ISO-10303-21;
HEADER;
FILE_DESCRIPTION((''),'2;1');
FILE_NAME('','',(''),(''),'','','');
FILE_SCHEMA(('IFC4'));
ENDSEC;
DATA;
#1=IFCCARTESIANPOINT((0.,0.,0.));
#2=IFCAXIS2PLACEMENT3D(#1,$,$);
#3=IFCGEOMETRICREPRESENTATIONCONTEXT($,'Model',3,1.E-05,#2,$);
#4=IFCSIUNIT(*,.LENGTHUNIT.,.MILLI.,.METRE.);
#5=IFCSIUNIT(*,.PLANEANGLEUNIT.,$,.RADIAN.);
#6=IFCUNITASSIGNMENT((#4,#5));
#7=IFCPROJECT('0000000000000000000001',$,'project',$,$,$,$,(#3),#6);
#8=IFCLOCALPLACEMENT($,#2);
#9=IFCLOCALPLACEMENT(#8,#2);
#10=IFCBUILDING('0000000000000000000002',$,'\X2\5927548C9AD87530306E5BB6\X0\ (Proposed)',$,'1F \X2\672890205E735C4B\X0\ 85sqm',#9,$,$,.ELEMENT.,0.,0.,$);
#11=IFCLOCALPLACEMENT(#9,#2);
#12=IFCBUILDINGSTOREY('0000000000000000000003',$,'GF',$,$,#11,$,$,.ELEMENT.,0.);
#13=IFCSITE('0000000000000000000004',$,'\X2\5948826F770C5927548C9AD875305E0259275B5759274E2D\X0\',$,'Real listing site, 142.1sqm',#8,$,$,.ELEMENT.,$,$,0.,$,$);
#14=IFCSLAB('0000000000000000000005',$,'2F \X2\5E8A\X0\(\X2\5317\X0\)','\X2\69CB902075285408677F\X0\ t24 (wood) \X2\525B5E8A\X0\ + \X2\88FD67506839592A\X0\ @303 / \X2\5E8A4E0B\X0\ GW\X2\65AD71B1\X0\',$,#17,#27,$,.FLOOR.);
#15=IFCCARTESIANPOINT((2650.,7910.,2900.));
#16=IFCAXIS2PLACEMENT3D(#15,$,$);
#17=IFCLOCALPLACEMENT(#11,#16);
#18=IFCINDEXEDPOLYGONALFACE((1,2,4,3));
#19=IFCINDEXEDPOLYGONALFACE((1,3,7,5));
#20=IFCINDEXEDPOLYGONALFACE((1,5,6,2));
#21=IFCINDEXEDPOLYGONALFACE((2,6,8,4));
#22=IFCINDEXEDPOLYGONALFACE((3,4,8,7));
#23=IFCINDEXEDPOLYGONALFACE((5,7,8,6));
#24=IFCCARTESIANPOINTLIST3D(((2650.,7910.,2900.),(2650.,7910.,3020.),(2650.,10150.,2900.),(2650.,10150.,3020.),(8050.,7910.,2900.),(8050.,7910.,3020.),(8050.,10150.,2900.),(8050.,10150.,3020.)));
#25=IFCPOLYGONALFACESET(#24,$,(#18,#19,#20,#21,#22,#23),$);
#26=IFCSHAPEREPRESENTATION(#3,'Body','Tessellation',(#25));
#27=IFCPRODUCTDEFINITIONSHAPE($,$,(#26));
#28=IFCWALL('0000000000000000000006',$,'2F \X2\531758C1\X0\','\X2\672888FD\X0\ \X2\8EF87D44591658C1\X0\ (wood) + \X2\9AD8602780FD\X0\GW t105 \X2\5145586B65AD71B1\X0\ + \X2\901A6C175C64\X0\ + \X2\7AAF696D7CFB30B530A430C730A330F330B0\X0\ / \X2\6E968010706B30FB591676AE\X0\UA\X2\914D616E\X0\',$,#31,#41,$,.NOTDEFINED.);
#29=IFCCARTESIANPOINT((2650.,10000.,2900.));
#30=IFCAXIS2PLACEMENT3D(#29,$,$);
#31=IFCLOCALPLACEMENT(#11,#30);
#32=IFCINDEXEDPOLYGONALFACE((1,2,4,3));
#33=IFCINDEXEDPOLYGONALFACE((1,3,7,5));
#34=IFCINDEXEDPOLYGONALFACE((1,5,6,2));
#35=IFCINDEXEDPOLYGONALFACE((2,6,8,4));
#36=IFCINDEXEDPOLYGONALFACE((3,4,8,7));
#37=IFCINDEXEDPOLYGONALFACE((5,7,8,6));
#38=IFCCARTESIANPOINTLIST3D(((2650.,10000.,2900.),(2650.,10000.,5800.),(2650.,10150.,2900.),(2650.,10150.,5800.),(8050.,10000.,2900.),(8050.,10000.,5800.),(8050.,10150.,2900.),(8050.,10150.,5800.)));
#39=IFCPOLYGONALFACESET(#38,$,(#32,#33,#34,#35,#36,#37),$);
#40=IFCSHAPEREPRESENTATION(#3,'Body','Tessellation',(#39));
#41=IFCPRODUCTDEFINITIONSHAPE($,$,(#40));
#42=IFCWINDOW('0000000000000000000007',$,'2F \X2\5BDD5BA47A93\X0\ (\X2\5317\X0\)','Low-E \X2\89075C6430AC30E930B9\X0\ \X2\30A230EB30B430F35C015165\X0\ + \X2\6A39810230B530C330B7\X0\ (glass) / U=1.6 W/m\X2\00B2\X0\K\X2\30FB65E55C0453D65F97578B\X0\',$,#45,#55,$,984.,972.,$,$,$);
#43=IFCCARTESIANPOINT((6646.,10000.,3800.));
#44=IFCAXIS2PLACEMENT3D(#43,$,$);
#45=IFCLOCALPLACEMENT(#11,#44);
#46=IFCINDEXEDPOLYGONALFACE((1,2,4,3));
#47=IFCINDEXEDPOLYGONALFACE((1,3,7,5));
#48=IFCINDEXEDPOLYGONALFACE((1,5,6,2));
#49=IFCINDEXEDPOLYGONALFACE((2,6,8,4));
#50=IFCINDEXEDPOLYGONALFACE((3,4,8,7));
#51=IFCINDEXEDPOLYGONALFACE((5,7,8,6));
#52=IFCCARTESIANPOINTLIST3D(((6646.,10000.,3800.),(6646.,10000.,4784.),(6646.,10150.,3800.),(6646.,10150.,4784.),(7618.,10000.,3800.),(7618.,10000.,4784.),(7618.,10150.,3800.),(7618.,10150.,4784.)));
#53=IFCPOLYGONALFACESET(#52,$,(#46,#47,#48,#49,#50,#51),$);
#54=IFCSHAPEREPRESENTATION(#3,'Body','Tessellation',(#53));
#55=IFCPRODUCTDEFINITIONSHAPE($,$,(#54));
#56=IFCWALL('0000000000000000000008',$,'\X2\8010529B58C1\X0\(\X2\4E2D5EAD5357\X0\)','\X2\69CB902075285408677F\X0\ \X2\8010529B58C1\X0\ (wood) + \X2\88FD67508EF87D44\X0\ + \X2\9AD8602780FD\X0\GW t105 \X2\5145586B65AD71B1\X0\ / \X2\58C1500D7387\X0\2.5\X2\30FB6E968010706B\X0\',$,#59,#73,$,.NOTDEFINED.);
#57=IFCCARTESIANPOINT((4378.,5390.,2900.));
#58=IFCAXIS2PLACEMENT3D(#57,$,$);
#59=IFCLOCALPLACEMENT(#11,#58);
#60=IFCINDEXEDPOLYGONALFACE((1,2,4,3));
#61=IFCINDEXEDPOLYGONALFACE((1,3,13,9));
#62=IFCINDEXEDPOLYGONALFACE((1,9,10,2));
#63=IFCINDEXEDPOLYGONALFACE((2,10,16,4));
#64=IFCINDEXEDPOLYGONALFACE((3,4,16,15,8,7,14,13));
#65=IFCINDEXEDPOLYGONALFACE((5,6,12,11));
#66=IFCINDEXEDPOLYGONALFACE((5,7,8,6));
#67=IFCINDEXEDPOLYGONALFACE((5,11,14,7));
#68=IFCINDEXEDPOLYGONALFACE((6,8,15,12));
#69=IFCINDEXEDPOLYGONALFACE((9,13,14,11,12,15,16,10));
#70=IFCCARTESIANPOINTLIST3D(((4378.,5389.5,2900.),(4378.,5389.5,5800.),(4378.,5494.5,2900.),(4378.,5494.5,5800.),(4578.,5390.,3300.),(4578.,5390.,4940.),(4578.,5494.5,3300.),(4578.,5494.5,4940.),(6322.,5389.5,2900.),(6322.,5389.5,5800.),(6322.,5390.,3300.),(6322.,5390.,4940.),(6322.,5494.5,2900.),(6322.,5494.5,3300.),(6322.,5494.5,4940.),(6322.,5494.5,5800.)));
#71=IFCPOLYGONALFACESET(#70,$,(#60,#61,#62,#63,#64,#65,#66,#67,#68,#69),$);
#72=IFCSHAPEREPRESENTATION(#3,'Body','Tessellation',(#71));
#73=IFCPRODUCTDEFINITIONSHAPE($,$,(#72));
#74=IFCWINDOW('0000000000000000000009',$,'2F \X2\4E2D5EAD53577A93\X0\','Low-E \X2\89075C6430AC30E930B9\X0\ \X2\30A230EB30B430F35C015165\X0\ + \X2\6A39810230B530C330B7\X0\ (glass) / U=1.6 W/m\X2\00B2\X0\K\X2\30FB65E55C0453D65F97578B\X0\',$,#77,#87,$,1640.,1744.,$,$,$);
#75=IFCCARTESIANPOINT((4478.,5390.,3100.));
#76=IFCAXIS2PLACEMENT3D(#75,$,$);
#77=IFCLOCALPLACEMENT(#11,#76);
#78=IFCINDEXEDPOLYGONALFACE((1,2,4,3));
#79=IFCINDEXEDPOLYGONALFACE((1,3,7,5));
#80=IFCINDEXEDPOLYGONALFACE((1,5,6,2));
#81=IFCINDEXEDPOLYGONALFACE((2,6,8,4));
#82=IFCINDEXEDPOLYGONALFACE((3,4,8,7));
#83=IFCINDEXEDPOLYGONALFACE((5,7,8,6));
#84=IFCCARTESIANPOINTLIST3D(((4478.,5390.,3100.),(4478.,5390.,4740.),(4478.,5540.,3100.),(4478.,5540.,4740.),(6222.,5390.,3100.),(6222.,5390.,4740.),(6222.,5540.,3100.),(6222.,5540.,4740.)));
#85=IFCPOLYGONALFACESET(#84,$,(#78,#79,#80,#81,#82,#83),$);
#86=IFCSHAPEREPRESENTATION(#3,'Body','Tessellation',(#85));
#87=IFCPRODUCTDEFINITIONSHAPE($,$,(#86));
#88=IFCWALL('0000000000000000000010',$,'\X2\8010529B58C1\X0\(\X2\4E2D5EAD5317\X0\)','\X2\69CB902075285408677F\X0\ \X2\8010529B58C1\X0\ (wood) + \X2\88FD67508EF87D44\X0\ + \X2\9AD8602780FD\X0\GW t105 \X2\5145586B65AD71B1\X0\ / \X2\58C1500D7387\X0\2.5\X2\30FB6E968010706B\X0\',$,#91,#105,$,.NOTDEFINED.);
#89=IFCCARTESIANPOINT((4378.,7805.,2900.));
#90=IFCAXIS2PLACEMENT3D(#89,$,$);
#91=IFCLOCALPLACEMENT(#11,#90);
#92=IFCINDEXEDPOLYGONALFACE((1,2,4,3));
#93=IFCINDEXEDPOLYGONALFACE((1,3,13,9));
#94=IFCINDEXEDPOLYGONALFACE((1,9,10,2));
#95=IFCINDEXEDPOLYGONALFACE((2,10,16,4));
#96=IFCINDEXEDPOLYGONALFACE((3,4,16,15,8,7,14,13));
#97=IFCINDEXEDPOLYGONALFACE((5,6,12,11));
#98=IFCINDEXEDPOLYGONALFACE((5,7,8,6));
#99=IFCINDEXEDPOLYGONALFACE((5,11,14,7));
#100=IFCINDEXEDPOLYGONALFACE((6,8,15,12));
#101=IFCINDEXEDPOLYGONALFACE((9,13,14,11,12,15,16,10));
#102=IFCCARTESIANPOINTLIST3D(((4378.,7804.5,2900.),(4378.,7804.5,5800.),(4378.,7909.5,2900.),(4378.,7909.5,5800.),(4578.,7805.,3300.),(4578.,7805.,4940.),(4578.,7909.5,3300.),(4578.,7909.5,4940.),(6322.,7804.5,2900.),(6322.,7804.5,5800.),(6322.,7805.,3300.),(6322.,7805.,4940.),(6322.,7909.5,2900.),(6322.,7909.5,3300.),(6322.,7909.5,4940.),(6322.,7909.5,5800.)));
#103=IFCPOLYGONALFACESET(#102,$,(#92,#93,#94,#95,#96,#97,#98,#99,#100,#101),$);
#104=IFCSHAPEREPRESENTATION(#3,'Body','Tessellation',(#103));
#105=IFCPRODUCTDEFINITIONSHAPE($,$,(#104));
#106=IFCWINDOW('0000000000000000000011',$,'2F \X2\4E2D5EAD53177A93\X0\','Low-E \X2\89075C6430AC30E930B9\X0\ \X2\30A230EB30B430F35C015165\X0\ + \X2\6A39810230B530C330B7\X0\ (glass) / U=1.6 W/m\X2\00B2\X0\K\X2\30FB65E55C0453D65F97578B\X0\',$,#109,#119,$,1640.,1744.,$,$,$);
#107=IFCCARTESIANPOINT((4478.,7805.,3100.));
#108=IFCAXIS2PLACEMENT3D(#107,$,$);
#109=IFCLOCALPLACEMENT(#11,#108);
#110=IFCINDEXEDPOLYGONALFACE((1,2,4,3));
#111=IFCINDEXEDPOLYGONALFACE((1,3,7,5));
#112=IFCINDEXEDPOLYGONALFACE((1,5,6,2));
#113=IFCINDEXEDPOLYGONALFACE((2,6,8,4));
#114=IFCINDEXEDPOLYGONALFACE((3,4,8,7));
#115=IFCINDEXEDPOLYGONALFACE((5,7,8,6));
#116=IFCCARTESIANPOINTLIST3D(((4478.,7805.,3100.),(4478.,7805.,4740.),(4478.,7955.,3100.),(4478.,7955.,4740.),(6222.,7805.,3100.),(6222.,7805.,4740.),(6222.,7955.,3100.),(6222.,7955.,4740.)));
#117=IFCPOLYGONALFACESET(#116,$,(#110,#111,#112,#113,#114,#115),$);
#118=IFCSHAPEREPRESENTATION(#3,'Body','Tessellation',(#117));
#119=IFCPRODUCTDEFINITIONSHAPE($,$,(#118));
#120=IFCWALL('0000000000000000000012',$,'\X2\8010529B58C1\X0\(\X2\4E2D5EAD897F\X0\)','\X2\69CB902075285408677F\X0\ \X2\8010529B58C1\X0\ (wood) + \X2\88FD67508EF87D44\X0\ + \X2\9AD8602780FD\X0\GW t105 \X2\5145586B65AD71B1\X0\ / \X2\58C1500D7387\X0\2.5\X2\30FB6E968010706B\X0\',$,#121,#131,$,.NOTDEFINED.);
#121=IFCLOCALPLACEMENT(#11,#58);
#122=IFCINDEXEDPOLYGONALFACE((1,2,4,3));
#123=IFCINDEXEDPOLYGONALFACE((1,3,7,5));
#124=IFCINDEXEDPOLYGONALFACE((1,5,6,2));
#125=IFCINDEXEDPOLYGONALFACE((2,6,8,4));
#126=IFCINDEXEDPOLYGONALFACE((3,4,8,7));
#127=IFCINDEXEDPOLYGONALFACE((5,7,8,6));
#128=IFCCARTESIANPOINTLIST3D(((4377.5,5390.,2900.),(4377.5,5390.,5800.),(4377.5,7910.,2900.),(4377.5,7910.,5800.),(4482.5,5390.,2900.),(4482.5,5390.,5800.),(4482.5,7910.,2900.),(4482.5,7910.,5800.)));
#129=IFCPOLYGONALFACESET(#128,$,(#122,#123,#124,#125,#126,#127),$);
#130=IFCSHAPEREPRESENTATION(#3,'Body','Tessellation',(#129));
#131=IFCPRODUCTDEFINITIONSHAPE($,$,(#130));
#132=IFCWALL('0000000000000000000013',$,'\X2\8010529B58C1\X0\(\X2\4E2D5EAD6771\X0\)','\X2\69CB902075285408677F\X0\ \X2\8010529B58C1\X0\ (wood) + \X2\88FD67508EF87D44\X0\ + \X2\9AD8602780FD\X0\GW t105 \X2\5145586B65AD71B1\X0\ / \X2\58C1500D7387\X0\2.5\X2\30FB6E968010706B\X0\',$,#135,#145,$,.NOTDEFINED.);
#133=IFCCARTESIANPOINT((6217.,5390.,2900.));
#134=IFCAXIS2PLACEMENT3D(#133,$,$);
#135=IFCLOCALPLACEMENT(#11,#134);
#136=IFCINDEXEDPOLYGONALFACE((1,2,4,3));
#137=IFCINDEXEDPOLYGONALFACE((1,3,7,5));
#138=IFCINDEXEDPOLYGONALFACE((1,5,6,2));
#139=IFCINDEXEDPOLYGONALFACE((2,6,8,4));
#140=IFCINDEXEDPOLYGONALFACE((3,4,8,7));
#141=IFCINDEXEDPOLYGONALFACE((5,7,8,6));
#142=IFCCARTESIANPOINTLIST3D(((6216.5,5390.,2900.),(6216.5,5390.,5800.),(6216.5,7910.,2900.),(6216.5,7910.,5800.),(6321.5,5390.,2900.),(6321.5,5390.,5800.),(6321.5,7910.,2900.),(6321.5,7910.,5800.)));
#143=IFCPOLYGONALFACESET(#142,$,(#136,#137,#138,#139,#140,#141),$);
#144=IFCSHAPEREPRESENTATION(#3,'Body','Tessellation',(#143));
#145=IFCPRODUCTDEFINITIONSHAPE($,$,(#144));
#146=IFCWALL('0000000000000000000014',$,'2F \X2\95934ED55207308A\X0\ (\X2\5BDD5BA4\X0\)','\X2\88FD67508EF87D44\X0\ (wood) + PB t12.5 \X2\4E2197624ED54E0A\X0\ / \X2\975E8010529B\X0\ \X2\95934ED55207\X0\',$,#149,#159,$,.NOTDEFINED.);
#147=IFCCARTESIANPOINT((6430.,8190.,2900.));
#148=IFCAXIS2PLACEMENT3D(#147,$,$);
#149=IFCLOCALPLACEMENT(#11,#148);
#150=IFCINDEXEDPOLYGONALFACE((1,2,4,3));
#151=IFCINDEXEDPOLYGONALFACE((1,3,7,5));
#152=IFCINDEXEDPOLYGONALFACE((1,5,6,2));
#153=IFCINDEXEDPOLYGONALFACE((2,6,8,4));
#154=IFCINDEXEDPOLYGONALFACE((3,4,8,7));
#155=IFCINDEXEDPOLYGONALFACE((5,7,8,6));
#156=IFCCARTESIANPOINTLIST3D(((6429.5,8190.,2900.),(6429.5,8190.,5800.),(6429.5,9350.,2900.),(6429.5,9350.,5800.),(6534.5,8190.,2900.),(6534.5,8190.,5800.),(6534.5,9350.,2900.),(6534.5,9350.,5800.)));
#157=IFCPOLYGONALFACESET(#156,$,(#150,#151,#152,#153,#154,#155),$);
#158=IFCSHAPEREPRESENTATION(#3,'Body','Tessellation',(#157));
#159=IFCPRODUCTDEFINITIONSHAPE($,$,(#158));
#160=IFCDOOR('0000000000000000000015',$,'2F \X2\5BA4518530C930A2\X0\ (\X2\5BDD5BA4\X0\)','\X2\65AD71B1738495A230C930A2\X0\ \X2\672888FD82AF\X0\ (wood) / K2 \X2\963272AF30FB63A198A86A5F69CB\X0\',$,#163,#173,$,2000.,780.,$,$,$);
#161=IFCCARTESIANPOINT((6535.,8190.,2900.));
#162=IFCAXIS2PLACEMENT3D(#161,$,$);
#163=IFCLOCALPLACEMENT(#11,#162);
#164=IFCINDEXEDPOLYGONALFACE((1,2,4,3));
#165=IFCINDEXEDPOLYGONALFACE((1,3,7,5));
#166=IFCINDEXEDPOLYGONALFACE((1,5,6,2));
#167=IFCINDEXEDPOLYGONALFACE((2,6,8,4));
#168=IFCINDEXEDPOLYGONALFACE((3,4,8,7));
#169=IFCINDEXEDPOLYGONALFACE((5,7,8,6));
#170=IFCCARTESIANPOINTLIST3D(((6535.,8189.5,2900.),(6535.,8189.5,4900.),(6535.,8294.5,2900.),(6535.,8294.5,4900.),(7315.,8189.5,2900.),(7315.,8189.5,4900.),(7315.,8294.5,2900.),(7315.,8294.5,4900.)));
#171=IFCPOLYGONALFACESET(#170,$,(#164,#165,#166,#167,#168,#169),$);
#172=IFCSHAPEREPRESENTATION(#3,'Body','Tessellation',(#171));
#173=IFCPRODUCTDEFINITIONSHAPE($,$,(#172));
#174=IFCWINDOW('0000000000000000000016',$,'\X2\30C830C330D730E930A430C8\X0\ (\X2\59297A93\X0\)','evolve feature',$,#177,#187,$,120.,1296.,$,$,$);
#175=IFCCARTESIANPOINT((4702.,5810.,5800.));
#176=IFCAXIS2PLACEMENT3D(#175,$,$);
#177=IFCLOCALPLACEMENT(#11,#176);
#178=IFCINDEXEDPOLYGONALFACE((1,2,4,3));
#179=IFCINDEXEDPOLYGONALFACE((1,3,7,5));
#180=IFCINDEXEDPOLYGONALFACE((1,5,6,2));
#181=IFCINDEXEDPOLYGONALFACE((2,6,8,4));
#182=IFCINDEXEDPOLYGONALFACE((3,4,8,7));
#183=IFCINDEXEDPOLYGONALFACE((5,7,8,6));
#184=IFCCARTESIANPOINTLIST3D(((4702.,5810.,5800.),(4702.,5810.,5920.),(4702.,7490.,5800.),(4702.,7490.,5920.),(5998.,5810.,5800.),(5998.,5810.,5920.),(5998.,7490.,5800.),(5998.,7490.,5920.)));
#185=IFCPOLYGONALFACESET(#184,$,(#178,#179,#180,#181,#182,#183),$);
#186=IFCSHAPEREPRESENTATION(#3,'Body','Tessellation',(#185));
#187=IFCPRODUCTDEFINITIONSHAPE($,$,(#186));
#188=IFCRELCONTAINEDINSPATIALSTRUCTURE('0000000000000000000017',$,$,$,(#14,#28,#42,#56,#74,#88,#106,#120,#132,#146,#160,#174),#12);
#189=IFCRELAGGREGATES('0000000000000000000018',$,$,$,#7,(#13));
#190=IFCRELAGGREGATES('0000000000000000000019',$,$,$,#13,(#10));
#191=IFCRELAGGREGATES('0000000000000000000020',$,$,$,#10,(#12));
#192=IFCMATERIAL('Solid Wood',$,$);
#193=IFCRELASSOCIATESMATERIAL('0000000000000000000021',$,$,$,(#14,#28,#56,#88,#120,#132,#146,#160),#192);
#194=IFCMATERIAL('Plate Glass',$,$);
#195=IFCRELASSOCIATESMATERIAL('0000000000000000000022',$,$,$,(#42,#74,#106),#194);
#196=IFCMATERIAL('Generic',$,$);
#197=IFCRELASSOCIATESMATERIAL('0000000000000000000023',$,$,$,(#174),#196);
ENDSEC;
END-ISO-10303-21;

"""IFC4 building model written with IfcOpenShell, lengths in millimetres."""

from ifc_helpers import new_model, si_unit, frame, frame_2d, origin, place, context, project, spatial, rectangle, extrude, material, element, fill, save


model = new_model("IFC4")

# Units and contexts
model_context = context("Model", 3, precision=1e-05, world=origin())
ifc_project = project(units=[si_unit("LENGTHUNIT", "METRE", prefix="MILLI"), si_unit("PLANEANGLEUNIT", "RADIAN")], contexts=[model_context])

# Site, building, storey
site_placement = place(None, origin())
site = spatial("IfcSite", under=ifc_project, at=site_placement, Name="奈良県大和高田市大字大中", ObjectType="Real listing site, 142.1sqm", CompositionType="ELEMENT", RefElevation=0.0)
building_placement = place(site_placement, origin())
building = spatial("IfcBuilding", under=site, at=building_placement, Name="大和高田の家 (Proposed)", ObjectType="1F 木造平屋 85sqm", CompositionType="ELEMENT", ElevationOfRefHeight=0.0, ElevationOfTerrain=0.0)
storey_placement = place(building_placement, origin())
storey = spatial("IfcBuildingStorey", under=building, at=storey_placement, Name="GF", CompositionType="ELEMENT", Elevation=0.0)

# Slab
ifc_material_1 = material(Name="Solid Wood")
slab_placement = place(storey_placement, frame((2650.0, 7910.0, 2900.0)))
element("IfcSlab", 1, at=slab_placement, inside=storey, material=ifc_material_1, Name="2F 床(北)", Description="構造用合板 t24 (wood) 剛床 + 製材根太 @303 / 床下 GW断熱", PredefinedType="FLOOR", context=model_context, shape_type="SweptSolid", body=[
    extrude(rectangle(XDim=5400.0, YDim=2240.0, at=frame_2d((2700.0, 1120.0))), frame((2650.0, 7910.0, 2900.0)), (0.0, 0.0, 1.0), 120.0),
])

# Walls, openings, windows
wall_1_placement = place(storey_placement, frame((2650.0, 10000.0, 2900.0)))
wall_1 = element("IfcWall", 2, at=wall_1_placement, inside=storey, material=ifc_material_1, Name="2F 北壁", Description="木製 軸組外壁 (wood) + 高性能GW t105 充填断熱 + 通気層 + 窯業系サイディング / 準耐火・外皮UA配慮", PredefinedType="NOTDEFINED", context=model_context, shape_type="SweptSolid", body=[
    extrude(rectangle(XDim=5400.0, YDim=150.0, at=frame_2d((2700.0, 75.0))), frame((2650.0, 10000.0, 2900.0)), (0.0, 0.0, 1.0), 2900.0),
])
opening_1_placement = place(storey_placement, frame((6646.0, 10000.0, 3800.0)))
opening_1 = element("IfcOpeningElement", 3, at=opening_1_placement, cuts=wall_1, PredefinedType="NOTDEFINED", context=model_context, shape_type="SweptSolid", body=[
    extrude(rectangle(XDim=972.0, YDim=150.0, at=frame_2d((486.0, 75.0))), frame((6646.0, 10000.0, 3800.0)), (0.0, 0.0, 1.0), 984.0),
])
ifc_material_2 = material(Name="Plate Glass")
window_1_placement = place(storey_placement, frame((6646.0, 10000.0, 3800.0)))
window_1 = element("IfcWindow", 4, at=window_1_placement, inside=storey, material=ifc_material_2, Name="2F 寝室窓 (北)", Description="Low-E 複層ガラス アルゴン封入 + 樹脂サッシ (glass) / U=1.6 W/m²K・日射取得型", OverallHeight=984.0, OverallWidth=972.0, context=model_context, shape_type="SweptSolid", body=[
    extrude(rectangle(XDim=972.0, YDim=150.0, at=frame_2d((486.0, 75.0))), frame((6646.0, 10000.0, 3800.0)), (0.0, 0.0, 1.0), 984.0),
])
fill(opening_1, window_1)
wall_2_placement = place(storey_placement, frame((4378.0, 5390.0, 2900.0)))
wall_2 = element("IfcWall", 5, at=wall_2_placement, inside=storey, material=ifc_material_1, Name="耐力壁(中庭南)", Description="構造用合板 耐力壁 (wood) + 製材軸組 + 高性能GW t105 充填断熱 / 壁倍率2.5・準耐火", PredefinedType="NOTDEFINED", context=model_context, shape_type="SweptSolid", body=[
    extrude(rectangle(XDim=1944.0, YDim=105.0, at=frame_2d((972.0, 52.0))), frame((4378.0, 5390.0, 2900.0)), (0.0, 0.0, 1.0), 2900.0),
])
opening_2_placement = place(storey_placement, frame((4478.0, 5390.0, 3100.0)))
opening_2 = element("IfcOpeningElement", 6, at=opening_2_placement, cuts=wall_2, PredefinedType="NOTDEFINED", context=model_context, shape_type="SweptSolid", body=[
    extrude(rectangle(XDim=1744.0, YDim=150.0, at=frame_2d((872.0, 75.0))), frame((4478.0, 5390.0, 3100.0)), (0.0, 0.0, 1.0), 1640.0),
])
window_2_placement = place(storey_placement, frame((4478.0, 5390.0, 3100.0)))
window_2 = element("IfcWindow", 7, at=window_2_placement, inside=storey, material=ifc_material_2, Name="2F 中庭南窓", Description="Low-E 複層ガラス アルゴン封入 + 樹脂サッシ (glass) / U=1.6 W/m²K・日射取得型", OverallHeight=1640.0, OverallWidth=1744.0, context=model_context, shape_type="SweptSolid", body=[
    extrude(rectangle(XDim=1744.0, YDim=150.0, at=frame_2d((872.0, 75.0))), frame((4478.0, 5390.0, 3100.0)), (0.0, 0.0, 1.0), 1640.0),
])
fill(opening_2, window_2)
wall_3_placement = place(storey_placement, frame((4378.0, 7805.0, 2900.0)))
wall_3 = element("IfcWall", 8, at=wall_3_placement, inside=storey, material=ifc_material_1, Name="耐力壁(中庭北)", Description="構造用合板 耐力壁 (wood) + 製材軸組 + 高性能GW t105 充填断熱 / 壁倍率2.5・準耐火", PredefinedType="NOTDEFINED", context=model_context, shape_type="SweptSolid", body=[
    extrude(rectangle(XDim=1944.0, YDim=105.0, at=frame_2d((972.0, 52.0))), frame((4378.0, 7805.0, 2900.0)), (0.0, 0.0, 1.0), 2900.0),
])
opening_3_placement = place(storey_placement, frame((4478.0, 7805.0, 3100.0)))
opening_3 = element("IfcOpeningElement", 9, at=opening_3_placement, cuts=wall_3, PredefinedType="NOTDEFINED", context=model_context, shape_type="SweptSolid", body=[
    extrude(rectangle(XDim=1744.0, YDim=150.0, at=frame_2d((872.0, 75.0))), frame((4478.0, 7805.0, 3100.0)), (0.0, 0.0, 1.0), 1640.0),
])
window_3_placement = place(storey_placement, frame((4478.0, 7805.0, 3100.0)))
window_3 = element("IfcWindow", 10, at=window_3_placement, inside=storey, material=ifc_material_2, Name="2F 中庭北窓", Description="Low-E 複層ガラス アルゴン封入 + 樹脂サッシ (glass) / U=1.6 W/m²K・日射取得型", OverallHeight=1640.0, OverallWidth=1744.0, context=model_context, shape_type="SweptSolid", body=[
    extrude(rectangle(XDim=1744.0, YDim=150.0, at=frame_2d((872.0, 75.0))), frame((4478.0, 7805.0, 3100.0)), (0.0, 0.0, 1.0), 1640.0),
])
fill(opening_3, window_3)

# Walls
wall_4_placement = place(storey_placement, frame((4378.0, 5390.0, 2900.0)))
element("IfcWall", 11, at=wall_4_placement, inside=storey, material=ifc_material_1, Name="耐力壁(中庭西)", Description="構造用合板 耐力壁 (wood) + 製材軸組 + 高性能GW t105 充填断熱 / 壁倍率2.5・準耐火", PredefinedType="NOTDEFINED", context=model_context, shape_type="SweptSolid", body=[
    extrude(rectangle(XDim=105.0, YDim=2520.0, at=frame_2d((52.0, 1260.0))), frame((4378.0, 5390.0, 2900.0)), (0.0, 0.0, 1.0), 2900.0),
])
wall_5_placement = place(storey_placement, frame((6217.0, 5390.0, 2900.0)))
element("IfcWall", 12, at=wall_5_placement, inside=storey, material=ifc_material_1, Name="耐力壁(中庭東)", Description="構造用合板 耐力壁 (wood) + 製材軸組 + 高性能GW t105 充填断熱 / 壁倍率2.5・準耐火", PredefinedType="NOTDEFINED", context=model_context, shape_type="SweptSolid", body=[
    extrude(rectangle(XDim=105.0, YDim=2520.0, at=frame_2d((52.0, 1260.0))), frame((6217.0, 5390.0, 2900.0)), (0.0, 0.0, 1.0), 2900.0),
])
wall_6_placement = place(storey_placement, frame((6430.0, 8190.0, 2900.0)))
element("IfcWall", 13, at=wall_6_placement, inside=storey, material=ifc_material_1, Name="2F 間仕切り (寝室)", Description="製材軸組 (wood) + PB t12.5 両面仕上 / 非耐力 間仕切", PredefinedType="NOTDEFINED", context=model_context, shape_type="SweptSolid", body=[
    extrude(rectangle(XDim=105.0, YDim=1160.0, at=frame_2d((52.0, 580.0))), frame((6430.0, 8190.0, 2900.0)), (0.0, 0.0, 1.0), 2900.0),
])

# Door
door_placement = place(storey_placement, frame((6535.0, 8190.0, 2900.0)))
element("IfcDoor", 14, at=door_placement, inside=storey, material=ifc_material_1, Name="2F 室内ドア (寝室)", Description="断熱玄関ドア 木製芯 (wood) / K2 防犯・採風機構", OverallHeight=2000.0, OverallWidth=780.0, context=model_context, shape_type="SweptSolid", body=[
    extrude(rectangle(XDim=780.0, YDim=105.0, at=frame_2d((390.0, 52.0))), frame((6535.0, 8190.0, 2900.0)), (0.0, 0.0, 1.0), 2000.0),
])

# Window
ifc_material_3 = material(Name="Generic")
window_4_placement = place(storey_placement, frame((4702.0, 5810.0, 5800.0)))
element("IfcWindow", 15, at=window_4_placement, inside=storey, material=ifc_material_3, Name="トップライト (天窓)", Description="evolve feature", OverallHeight=120.0, OverallWidth=1296.0, context=model_context, shape_type="SweptSolid", body=[
    extrude(rectangle(XDim=1296.0, YDim=1680.0, at=frame_2d((648.0, 840.0))), frame((4702.0, 5810.0, 5800.0)), (0.0, 0.0, 1.0), 120.0),
])

save(model, "model.ifc")
